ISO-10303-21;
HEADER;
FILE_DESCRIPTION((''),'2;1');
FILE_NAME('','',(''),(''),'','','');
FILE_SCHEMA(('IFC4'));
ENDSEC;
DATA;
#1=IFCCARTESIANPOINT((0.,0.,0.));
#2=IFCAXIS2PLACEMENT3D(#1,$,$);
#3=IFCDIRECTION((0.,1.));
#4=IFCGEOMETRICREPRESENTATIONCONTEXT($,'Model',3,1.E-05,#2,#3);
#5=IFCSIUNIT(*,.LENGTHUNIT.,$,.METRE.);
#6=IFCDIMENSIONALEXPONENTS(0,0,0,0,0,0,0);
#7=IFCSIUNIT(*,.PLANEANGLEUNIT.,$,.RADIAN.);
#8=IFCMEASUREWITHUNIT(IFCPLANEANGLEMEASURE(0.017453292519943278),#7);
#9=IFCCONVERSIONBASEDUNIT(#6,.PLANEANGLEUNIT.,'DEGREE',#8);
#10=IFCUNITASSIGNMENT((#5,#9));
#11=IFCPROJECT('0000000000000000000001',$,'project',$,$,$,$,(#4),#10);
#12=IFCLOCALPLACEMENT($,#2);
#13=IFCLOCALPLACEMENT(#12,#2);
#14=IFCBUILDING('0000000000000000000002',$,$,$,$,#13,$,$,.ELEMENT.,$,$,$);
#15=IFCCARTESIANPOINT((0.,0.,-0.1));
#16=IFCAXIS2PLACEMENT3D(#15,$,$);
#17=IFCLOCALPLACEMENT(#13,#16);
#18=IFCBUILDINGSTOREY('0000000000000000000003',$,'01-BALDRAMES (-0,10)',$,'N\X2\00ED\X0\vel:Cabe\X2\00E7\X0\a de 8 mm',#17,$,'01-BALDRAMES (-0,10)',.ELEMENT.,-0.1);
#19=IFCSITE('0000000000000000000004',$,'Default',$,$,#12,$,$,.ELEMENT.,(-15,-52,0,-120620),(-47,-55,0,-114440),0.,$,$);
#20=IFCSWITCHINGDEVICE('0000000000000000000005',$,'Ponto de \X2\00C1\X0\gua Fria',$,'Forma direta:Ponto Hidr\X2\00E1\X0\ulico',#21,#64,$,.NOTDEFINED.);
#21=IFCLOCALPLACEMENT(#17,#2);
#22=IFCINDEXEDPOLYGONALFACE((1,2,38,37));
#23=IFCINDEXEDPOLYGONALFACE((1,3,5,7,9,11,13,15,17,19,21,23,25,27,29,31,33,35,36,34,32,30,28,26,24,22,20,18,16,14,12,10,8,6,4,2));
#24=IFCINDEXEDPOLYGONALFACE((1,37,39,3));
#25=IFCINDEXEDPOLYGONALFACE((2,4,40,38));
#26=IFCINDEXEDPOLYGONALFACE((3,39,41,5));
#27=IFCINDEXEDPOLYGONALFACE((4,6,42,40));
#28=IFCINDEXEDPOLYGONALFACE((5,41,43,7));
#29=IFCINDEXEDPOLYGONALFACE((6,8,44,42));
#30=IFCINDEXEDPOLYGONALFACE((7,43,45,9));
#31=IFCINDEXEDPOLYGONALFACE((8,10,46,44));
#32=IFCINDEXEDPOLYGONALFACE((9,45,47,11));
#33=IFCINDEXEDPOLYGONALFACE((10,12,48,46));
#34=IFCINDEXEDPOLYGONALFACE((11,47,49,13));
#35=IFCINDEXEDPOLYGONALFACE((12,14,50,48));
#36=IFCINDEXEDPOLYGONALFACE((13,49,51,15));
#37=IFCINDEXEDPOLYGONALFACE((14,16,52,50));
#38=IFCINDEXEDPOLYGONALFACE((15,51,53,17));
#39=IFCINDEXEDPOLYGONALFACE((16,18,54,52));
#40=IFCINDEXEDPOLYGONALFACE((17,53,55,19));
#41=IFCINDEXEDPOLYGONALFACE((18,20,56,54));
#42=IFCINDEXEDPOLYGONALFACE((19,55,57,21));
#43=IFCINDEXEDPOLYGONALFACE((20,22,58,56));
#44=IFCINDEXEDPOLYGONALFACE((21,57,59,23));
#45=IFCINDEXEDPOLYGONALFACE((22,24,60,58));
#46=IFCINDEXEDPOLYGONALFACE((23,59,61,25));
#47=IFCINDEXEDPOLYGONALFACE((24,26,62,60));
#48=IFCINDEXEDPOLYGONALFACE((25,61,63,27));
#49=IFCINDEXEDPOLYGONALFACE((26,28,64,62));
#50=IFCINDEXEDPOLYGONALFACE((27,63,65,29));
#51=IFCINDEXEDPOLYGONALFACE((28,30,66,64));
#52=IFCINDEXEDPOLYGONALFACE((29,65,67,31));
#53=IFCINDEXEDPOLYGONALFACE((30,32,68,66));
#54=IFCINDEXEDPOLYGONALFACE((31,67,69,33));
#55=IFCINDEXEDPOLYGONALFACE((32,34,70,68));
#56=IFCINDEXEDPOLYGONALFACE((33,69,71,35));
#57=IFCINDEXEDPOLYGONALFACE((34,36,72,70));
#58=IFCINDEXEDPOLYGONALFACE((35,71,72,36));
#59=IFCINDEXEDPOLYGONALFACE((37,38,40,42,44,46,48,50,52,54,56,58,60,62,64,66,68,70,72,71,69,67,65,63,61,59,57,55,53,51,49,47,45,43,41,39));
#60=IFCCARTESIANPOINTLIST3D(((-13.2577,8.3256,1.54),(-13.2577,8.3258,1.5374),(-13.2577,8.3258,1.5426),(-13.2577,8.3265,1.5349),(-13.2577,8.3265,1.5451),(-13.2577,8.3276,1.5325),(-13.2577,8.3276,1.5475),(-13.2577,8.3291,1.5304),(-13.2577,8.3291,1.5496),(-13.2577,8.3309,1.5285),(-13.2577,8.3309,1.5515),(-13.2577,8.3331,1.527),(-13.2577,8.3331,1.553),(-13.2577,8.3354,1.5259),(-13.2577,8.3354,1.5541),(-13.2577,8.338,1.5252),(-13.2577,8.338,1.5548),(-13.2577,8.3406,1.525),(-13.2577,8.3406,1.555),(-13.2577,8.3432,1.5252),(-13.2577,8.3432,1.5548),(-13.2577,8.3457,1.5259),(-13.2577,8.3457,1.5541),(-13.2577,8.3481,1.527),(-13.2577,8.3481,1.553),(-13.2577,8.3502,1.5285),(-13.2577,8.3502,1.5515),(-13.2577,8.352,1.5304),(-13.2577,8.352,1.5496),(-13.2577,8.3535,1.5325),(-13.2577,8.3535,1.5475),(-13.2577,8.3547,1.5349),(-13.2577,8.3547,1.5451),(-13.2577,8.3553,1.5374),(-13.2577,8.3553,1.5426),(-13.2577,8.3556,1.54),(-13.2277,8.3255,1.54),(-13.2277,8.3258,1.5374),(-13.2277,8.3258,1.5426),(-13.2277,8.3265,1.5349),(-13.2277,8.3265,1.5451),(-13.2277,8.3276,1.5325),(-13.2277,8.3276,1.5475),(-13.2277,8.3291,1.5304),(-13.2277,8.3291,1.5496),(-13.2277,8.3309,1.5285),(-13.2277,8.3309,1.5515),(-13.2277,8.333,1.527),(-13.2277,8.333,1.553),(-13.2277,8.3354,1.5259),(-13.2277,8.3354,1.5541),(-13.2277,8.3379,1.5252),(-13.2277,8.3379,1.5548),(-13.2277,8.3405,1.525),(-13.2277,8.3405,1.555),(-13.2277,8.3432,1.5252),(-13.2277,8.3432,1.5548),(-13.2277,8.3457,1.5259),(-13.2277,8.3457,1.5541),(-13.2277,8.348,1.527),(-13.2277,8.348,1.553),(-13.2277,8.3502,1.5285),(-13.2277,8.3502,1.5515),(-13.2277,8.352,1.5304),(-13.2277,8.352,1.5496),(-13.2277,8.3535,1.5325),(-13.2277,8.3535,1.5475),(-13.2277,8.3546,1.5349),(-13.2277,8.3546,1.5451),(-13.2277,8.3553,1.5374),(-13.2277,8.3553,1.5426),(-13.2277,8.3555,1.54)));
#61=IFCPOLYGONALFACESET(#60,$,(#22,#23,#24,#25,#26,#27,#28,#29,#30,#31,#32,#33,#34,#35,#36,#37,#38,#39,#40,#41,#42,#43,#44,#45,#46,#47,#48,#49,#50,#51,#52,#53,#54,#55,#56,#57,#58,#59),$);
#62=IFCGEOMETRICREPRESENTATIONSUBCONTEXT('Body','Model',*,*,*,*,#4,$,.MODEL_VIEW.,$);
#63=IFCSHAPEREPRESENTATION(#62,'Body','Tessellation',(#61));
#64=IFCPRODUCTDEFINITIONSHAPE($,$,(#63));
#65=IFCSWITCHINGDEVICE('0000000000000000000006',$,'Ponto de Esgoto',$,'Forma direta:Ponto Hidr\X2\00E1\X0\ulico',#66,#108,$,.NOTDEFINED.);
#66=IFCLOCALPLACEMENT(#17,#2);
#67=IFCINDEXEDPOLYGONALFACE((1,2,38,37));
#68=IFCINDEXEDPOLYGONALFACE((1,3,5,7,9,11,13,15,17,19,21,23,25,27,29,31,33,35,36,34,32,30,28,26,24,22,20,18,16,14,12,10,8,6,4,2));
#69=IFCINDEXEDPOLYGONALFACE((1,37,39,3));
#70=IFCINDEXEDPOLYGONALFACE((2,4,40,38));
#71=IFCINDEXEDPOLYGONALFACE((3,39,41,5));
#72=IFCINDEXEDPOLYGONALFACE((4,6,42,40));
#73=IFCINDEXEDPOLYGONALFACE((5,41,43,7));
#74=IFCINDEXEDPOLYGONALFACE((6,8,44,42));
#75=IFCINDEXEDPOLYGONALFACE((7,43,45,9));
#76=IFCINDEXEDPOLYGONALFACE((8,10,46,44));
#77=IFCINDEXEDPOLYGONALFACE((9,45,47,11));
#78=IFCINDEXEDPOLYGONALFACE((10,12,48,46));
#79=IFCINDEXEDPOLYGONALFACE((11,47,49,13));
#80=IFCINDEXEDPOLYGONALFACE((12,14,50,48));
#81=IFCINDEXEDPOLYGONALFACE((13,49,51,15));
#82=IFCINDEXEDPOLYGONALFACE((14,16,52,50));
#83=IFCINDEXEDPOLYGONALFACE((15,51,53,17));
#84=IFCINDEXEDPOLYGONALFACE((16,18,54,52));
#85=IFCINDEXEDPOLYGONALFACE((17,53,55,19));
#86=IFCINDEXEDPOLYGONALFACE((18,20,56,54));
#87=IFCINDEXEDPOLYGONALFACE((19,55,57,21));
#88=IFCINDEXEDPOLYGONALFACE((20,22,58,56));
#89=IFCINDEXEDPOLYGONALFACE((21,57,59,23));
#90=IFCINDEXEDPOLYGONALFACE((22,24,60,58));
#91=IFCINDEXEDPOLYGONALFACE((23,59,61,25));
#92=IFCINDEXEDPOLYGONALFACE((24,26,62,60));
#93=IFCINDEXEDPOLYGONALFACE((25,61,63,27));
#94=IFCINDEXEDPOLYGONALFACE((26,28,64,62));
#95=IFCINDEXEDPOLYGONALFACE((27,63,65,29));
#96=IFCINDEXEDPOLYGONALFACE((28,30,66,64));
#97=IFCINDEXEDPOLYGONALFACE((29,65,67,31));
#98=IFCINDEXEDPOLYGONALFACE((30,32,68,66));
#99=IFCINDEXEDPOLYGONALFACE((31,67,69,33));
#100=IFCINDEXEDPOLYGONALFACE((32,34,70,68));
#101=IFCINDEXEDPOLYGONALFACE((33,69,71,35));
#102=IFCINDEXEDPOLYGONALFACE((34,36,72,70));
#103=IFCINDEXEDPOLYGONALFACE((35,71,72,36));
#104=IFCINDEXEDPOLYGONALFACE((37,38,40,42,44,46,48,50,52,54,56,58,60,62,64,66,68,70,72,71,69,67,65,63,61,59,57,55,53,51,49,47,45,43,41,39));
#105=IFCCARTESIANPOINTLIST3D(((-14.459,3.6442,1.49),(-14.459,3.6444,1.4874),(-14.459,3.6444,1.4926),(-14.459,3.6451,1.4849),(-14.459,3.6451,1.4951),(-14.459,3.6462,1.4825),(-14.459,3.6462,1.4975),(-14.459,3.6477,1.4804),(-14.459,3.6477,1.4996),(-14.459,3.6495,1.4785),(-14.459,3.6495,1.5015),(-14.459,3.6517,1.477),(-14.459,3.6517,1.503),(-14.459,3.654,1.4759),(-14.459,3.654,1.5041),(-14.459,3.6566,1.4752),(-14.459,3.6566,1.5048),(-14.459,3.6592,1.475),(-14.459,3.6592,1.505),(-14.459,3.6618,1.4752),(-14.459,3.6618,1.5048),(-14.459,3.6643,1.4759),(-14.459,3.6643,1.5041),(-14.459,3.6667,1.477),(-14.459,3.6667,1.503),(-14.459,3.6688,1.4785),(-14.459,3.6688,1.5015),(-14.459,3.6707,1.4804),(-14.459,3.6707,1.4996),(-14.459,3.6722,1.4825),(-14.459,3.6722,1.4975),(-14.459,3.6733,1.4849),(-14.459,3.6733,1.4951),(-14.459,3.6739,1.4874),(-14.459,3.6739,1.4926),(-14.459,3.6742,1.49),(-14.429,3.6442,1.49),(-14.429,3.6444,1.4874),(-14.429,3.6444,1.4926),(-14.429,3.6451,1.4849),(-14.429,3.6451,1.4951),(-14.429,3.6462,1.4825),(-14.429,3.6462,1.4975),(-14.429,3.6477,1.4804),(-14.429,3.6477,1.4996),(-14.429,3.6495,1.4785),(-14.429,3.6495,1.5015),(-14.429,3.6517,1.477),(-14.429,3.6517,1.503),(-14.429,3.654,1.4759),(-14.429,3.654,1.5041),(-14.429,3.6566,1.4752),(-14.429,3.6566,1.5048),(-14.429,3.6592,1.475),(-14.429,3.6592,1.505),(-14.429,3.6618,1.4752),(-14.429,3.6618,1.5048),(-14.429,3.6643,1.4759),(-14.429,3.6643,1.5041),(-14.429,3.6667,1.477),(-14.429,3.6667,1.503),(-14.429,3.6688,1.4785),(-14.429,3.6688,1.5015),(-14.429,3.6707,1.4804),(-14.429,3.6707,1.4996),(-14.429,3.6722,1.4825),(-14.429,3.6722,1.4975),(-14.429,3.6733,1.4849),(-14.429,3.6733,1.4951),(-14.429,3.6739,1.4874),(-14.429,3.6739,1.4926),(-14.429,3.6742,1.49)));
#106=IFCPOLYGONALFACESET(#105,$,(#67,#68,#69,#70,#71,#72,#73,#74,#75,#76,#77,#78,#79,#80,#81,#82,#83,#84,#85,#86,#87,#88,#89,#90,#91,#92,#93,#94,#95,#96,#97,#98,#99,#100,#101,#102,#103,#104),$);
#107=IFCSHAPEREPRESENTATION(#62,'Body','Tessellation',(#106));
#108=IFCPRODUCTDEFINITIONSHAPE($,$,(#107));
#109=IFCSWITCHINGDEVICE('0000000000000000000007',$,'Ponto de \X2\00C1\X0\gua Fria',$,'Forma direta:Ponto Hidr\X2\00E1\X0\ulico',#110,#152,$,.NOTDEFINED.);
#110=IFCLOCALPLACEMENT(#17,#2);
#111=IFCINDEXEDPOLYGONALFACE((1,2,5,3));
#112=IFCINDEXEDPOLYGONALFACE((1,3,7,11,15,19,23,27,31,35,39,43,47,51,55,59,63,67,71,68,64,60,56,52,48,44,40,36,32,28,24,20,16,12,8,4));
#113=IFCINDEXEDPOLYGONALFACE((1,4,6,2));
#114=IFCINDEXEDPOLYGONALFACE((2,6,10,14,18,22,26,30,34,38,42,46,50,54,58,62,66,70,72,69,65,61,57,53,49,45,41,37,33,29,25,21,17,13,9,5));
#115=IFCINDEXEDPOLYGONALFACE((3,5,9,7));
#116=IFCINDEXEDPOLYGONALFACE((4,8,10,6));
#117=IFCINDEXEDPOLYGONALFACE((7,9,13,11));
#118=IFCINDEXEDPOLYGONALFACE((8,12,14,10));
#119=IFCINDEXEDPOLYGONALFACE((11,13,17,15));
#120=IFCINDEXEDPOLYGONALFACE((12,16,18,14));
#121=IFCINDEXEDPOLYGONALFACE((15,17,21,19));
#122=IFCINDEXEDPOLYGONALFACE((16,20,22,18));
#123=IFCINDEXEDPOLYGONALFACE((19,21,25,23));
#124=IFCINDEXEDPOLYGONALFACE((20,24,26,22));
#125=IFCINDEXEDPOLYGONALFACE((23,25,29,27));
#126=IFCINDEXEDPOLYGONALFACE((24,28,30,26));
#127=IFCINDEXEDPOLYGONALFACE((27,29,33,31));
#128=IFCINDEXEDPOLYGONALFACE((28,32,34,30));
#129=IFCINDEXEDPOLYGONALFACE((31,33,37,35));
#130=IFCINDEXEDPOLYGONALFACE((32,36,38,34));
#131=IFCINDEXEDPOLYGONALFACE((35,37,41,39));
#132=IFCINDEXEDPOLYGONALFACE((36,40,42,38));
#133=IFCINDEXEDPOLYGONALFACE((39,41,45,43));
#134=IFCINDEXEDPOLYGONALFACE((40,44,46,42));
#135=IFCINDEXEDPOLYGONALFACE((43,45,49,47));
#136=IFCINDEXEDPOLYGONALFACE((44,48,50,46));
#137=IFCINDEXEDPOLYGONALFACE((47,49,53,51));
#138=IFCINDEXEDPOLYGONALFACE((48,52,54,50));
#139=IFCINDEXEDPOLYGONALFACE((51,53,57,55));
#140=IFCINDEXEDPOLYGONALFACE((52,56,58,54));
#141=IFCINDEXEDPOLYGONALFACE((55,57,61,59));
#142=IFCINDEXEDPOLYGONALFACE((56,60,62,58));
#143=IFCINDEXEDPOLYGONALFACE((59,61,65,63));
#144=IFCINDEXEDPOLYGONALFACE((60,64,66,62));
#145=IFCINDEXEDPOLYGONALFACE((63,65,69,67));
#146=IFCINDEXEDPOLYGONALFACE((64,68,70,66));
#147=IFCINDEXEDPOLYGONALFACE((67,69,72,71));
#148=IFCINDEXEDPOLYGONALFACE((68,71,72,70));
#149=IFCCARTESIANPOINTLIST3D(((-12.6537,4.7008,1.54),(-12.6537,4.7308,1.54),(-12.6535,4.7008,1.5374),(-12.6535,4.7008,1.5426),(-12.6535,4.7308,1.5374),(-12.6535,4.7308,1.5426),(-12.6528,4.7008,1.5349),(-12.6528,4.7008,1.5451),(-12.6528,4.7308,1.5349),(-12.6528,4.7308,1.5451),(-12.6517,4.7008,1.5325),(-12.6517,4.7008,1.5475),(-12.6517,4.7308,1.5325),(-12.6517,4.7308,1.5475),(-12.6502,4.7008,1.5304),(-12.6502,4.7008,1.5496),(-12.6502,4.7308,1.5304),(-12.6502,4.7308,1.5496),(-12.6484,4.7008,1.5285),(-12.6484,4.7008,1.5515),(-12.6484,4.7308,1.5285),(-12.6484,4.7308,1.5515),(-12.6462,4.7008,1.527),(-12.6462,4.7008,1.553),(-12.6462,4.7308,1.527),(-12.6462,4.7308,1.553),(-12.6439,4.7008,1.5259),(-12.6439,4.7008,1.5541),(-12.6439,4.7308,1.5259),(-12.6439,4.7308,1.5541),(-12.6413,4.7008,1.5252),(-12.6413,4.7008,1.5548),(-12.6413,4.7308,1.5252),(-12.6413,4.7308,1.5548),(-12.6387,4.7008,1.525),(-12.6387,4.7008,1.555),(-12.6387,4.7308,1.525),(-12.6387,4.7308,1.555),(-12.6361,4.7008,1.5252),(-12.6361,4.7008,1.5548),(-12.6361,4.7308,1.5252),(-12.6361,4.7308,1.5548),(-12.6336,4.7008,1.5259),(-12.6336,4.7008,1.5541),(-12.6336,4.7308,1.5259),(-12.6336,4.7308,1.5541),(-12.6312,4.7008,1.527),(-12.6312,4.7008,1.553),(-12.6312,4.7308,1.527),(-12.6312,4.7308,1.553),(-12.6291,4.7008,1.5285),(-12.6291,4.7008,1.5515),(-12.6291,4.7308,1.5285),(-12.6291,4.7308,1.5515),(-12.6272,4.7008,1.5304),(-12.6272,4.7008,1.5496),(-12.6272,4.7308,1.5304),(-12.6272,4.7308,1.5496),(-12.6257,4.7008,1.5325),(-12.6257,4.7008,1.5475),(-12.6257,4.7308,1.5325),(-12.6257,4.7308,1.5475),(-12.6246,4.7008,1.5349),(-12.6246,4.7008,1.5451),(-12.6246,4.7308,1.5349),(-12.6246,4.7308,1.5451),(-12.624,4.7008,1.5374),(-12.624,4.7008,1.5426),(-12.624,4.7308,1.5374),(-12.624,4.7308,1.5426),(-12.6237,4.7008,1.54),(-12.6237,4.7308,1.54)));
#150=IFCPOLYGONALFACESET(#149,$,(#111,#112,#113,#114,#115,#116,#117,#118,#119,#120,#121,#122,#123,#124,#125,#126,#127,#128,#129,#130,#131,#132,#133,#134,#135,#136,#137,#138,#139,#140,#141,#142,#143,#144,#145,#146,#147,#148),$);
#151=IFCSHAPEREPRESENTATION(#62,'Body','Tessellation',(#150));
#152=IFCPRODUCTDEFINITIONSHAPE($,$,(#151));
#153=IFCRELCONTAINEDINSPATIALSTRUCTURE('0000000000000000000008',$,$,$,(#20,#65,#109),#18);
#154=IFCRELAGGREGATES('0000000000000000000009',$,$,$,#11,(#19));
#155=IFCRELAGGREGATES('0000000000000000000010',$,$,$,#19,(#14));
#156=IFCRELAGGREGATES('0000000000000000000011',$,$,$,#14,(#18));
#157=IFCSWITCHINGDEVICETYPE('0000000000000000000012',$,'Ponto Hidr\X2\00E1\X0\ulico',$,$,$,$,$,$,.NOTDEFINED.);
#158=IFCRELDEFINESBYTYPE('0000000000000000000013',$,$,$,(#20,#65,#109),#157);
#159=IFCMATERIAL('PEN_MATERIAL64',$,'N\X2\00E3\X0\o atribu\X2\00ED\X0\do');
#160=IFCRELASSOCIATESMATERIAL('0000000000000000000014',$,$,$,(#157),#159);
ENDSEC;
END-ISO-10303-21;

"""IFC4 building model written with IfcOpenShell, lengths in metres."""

from ifc_helpers import new_model, entity, si_unit, converted_unit, direction, frame, origin, place, context, subcontext, project, spatial, indexed_curve, outline, extrude, material, type_object, element, save


model = new_model("IFC4")

# Units and contexts
model_context = context("Model", 3, precision=1e-05, world=origin(), true_north=direction((0.0, 1.0)))
body_context = subcontext(model_context, "Body", "Model", "MODEL_VIEW")
ifc_project = project(units=[si_unit("LENGTHUNIT", "METRE"), converted_unit("PLANEANGLEUNIT", "DEGREE", entity("IfcPlaneAngleMeasure", 0.017453292519943278), si_unit("PLANEANGLEUNIT", "RADIAN"), dimensions=[0, 0, 0, 0, 0, 0, 0])], contexts=[model_context])

# Site, building, storey
site_placement = place(None, origin())
site = spatial("IfcSite", under=ifc_project, at=site_placement, Name="Default", CompositionType="ELEMENT", RefLatitude=(-15, -52, 0, -120620), RefLongitude=(-47, -55, 0, -114440), RefElevation=0.0)
building_placement = place(site_placement, origin())
building = spatial("IfcBuilding", under=site, at=building_placement, CompositionType="ELEMENT")
storey_placement = place(building_placement, frame((0.0, 0.0, -0.1)))
storey = spatial("IfcBuildingStorey", under=building, at=storey_placement, Name="01-BALDRAMES (-0,10)", ObjectType="Nível:Cabeça de 8 mm", LongName="01-BALDRAMES (-0,10)", CompositionType="ELEMENT", Elevation=-0.1)

# Switching devices
ifc_material_1 = material(Name="PEN_MATERIAL64", Category="Não atribuído")
switching_device_type = type_object("IfcSwitchingDeviceType", Name="Ponto Hidráulico", PredefinedType="NOTDEFINED", material=ifc_material_1)
switching_device_1_placement = place(storey_placement, origin())
element("IfcSwitchingDevice", 1, at=switching_device_1_placement, inside=storey, type_object=switching_device_type, Name="Ponto de Água Fria", ObjectType="Forma direta:Ponto Hidráulico", PredefinedType="NOTDEFINED", context=body_context, shape_type="SweptSolid", body=[
    extrude(outline(indexed_curve([(-0.0013, -0.0149), (0.0013, -0.0149), (0.0039, -0.0145), (0.0063, -0.0136), (0.0086, -0.0123), (0.0106, -0.0106), (0.0123, -0.0086), (0.0136, -0.0063), (0.0145, -0.0039), (0.0149, -0.0013), (0.0149, 0.0013), (0.0145, 0.0039), (0.0136, 0.0063), (0.0123, 0.0086), (0.0106, 0.0106), (0.0086, 0.0123), (0.0063, 0.0136), (0.0039, 0.0145), (0.0013, 0.0149), (-0.0013, 0.0149), (-0.0039, 0.0145), (-0.0063, 0.0136), (-0.0086, 0.0123), (-0.0106, 0.0106), (-0.0123, 0.0086), (-0.0136, 0.0063), (-0.0145, 0.0039), (-0.0149, 0.0013), (-0.0149, -0.0013), (-0.0145, -0.0039), (-0.0136, -0.0063), (-0.0123, -0.0086), (-0.0106, -0.0106), (-0.0086, -0.0123), (-0.0063, -0.0136), (-0.0039, -0.0145), (-0.0013, -0.0149)], self_intersect=False)), frame((-13.2577, 8.3406, 1.54), z_axis=(1.0, -0.000299, 0.0), x_axis=(0.000289, 0.965926, 0.258819)), (0.0, 0.0, 1.0), 0.03),
])
switching_device_2_placement = place(storey_placement, origin())
element("IfcSwitchingDevice", 2, at=switching_device_2_placement, inside=storey, type_object=switching_device_type, Name="Ponto de Esgoto", ObjectType="Forma direta:Ponto Hidráulico", PredefinedType="NOTDEFINED", context=body_context, shape_type="SweptSolid", body=[
    extrude(outline(indexed_curve([(-0.0013, -0.0149), (0.0013, -0.0149), (0.0039, -0.0145), (0.0063, -0.0136), (0.0086, -0.0123), (0.0106, -0.0106), (0.0123, -0.0086), (0.0136, -0.0063), (0.0145, -0.0039), (0.0149, -0.0013), (0.0149, 0.0013), (0.0145, 0.0039), (0.0136, 0.0063), (0.0123, 0.0086), (0.0106, 0.0106), (0.0086, 0.0123), (0.0063, 0.0136), (0.0039, 0.0145), (0.0013, 0.0149), (-0.0013, 0.0149), (-0.0039, 0.0145), (-0.0063, 0.0136), (-0.0086, 0.0123), (-0.0106, 0.0106), (-0.0123, 0.0086), (-0.0136, 0.0063), (-0.0145, 0.0039), (-0.0149, 0.0013), (-0.0149, -0.0013), (-0.0145, -0.0039), (-0.0136, -0.0063), (-0.0123, -0.0086), (-0.0106, -0.0106), (-0.0086, -0.0123), (-0.0063, -0.0136), (-0.0039, -0.0145), (-0.0013, -0.0149)], self_intersect=False)), frame((-14.459, 3.6592, 1.49), z_axis=(1.0, -0.000299, 0.0), x_axis=(0.000289, 0.965926, 0.258819)), (0.0, 0.0, 1.0), 0.03),
])
switching_device_3_placement = place(storey_placement, origin())
element("IfcSwitchingDevice", 3, at=switching_device_3_placement, inside=storey, type_object=switching_device_type, Name="Ponto de Água Fria", ObjectType="Forma direta:Ponto Hidráulico", PredefinedType="NOTDEFINED", context=body_context, shape_type="SweptSolid", body=[
    extrude(outline(indexed_curve([(-0.0013, -0.0149), (0.0013, -0.0149), (0.0039, -0.0145), (0.0063, -0.0136), (0.0086, -0.0123), (0.0106, -0.0106), (0.0123, -0.0086), (0.0136, -0.0063), (0.0145, -0.0039), (0.0149, -0.0013), (0.0149, 0.0013), (0.0145, 0.0039), (0.0136, 0.0063), (0.0123, 0.0086), (0.0106, 0.0106), (0.0086, 0.0123), (0.0063, 0.0136), (0.0039, 0.0145), (0.0013, 0.0149), (-0.0013, 0.0149), (-0.0039, 0.0145), (-0.0063, 0.0136), (-0.0086, 0.0123), (-0.0106, 0.0106), (-0.0123, 0.0086), (-0.0136, 0.0063), (-0.0145, 0.0039), (-0.0149, 0.0013), (-0.0149, -0.0013), (-0.0145, -0.0039), (-0.0136, -0.0063), (-0.0123, -0.0086), (-0.0106, -0.0106), (-0.0086, -0.0123), (-0.0063, -0.0136), (-0.0039, -0.0145), (-0.0013, -0.0149)], self_intersect=False)), frame((-12.6387, 4.7008, 1.54), z_axis=(0.000299, 1.0, 0.0), x_axis=(-0.996195, 0.000298, -0.087156)), (0.0, 0.0, 1.0), 0.03),
])

save(model, "model.ifc")
